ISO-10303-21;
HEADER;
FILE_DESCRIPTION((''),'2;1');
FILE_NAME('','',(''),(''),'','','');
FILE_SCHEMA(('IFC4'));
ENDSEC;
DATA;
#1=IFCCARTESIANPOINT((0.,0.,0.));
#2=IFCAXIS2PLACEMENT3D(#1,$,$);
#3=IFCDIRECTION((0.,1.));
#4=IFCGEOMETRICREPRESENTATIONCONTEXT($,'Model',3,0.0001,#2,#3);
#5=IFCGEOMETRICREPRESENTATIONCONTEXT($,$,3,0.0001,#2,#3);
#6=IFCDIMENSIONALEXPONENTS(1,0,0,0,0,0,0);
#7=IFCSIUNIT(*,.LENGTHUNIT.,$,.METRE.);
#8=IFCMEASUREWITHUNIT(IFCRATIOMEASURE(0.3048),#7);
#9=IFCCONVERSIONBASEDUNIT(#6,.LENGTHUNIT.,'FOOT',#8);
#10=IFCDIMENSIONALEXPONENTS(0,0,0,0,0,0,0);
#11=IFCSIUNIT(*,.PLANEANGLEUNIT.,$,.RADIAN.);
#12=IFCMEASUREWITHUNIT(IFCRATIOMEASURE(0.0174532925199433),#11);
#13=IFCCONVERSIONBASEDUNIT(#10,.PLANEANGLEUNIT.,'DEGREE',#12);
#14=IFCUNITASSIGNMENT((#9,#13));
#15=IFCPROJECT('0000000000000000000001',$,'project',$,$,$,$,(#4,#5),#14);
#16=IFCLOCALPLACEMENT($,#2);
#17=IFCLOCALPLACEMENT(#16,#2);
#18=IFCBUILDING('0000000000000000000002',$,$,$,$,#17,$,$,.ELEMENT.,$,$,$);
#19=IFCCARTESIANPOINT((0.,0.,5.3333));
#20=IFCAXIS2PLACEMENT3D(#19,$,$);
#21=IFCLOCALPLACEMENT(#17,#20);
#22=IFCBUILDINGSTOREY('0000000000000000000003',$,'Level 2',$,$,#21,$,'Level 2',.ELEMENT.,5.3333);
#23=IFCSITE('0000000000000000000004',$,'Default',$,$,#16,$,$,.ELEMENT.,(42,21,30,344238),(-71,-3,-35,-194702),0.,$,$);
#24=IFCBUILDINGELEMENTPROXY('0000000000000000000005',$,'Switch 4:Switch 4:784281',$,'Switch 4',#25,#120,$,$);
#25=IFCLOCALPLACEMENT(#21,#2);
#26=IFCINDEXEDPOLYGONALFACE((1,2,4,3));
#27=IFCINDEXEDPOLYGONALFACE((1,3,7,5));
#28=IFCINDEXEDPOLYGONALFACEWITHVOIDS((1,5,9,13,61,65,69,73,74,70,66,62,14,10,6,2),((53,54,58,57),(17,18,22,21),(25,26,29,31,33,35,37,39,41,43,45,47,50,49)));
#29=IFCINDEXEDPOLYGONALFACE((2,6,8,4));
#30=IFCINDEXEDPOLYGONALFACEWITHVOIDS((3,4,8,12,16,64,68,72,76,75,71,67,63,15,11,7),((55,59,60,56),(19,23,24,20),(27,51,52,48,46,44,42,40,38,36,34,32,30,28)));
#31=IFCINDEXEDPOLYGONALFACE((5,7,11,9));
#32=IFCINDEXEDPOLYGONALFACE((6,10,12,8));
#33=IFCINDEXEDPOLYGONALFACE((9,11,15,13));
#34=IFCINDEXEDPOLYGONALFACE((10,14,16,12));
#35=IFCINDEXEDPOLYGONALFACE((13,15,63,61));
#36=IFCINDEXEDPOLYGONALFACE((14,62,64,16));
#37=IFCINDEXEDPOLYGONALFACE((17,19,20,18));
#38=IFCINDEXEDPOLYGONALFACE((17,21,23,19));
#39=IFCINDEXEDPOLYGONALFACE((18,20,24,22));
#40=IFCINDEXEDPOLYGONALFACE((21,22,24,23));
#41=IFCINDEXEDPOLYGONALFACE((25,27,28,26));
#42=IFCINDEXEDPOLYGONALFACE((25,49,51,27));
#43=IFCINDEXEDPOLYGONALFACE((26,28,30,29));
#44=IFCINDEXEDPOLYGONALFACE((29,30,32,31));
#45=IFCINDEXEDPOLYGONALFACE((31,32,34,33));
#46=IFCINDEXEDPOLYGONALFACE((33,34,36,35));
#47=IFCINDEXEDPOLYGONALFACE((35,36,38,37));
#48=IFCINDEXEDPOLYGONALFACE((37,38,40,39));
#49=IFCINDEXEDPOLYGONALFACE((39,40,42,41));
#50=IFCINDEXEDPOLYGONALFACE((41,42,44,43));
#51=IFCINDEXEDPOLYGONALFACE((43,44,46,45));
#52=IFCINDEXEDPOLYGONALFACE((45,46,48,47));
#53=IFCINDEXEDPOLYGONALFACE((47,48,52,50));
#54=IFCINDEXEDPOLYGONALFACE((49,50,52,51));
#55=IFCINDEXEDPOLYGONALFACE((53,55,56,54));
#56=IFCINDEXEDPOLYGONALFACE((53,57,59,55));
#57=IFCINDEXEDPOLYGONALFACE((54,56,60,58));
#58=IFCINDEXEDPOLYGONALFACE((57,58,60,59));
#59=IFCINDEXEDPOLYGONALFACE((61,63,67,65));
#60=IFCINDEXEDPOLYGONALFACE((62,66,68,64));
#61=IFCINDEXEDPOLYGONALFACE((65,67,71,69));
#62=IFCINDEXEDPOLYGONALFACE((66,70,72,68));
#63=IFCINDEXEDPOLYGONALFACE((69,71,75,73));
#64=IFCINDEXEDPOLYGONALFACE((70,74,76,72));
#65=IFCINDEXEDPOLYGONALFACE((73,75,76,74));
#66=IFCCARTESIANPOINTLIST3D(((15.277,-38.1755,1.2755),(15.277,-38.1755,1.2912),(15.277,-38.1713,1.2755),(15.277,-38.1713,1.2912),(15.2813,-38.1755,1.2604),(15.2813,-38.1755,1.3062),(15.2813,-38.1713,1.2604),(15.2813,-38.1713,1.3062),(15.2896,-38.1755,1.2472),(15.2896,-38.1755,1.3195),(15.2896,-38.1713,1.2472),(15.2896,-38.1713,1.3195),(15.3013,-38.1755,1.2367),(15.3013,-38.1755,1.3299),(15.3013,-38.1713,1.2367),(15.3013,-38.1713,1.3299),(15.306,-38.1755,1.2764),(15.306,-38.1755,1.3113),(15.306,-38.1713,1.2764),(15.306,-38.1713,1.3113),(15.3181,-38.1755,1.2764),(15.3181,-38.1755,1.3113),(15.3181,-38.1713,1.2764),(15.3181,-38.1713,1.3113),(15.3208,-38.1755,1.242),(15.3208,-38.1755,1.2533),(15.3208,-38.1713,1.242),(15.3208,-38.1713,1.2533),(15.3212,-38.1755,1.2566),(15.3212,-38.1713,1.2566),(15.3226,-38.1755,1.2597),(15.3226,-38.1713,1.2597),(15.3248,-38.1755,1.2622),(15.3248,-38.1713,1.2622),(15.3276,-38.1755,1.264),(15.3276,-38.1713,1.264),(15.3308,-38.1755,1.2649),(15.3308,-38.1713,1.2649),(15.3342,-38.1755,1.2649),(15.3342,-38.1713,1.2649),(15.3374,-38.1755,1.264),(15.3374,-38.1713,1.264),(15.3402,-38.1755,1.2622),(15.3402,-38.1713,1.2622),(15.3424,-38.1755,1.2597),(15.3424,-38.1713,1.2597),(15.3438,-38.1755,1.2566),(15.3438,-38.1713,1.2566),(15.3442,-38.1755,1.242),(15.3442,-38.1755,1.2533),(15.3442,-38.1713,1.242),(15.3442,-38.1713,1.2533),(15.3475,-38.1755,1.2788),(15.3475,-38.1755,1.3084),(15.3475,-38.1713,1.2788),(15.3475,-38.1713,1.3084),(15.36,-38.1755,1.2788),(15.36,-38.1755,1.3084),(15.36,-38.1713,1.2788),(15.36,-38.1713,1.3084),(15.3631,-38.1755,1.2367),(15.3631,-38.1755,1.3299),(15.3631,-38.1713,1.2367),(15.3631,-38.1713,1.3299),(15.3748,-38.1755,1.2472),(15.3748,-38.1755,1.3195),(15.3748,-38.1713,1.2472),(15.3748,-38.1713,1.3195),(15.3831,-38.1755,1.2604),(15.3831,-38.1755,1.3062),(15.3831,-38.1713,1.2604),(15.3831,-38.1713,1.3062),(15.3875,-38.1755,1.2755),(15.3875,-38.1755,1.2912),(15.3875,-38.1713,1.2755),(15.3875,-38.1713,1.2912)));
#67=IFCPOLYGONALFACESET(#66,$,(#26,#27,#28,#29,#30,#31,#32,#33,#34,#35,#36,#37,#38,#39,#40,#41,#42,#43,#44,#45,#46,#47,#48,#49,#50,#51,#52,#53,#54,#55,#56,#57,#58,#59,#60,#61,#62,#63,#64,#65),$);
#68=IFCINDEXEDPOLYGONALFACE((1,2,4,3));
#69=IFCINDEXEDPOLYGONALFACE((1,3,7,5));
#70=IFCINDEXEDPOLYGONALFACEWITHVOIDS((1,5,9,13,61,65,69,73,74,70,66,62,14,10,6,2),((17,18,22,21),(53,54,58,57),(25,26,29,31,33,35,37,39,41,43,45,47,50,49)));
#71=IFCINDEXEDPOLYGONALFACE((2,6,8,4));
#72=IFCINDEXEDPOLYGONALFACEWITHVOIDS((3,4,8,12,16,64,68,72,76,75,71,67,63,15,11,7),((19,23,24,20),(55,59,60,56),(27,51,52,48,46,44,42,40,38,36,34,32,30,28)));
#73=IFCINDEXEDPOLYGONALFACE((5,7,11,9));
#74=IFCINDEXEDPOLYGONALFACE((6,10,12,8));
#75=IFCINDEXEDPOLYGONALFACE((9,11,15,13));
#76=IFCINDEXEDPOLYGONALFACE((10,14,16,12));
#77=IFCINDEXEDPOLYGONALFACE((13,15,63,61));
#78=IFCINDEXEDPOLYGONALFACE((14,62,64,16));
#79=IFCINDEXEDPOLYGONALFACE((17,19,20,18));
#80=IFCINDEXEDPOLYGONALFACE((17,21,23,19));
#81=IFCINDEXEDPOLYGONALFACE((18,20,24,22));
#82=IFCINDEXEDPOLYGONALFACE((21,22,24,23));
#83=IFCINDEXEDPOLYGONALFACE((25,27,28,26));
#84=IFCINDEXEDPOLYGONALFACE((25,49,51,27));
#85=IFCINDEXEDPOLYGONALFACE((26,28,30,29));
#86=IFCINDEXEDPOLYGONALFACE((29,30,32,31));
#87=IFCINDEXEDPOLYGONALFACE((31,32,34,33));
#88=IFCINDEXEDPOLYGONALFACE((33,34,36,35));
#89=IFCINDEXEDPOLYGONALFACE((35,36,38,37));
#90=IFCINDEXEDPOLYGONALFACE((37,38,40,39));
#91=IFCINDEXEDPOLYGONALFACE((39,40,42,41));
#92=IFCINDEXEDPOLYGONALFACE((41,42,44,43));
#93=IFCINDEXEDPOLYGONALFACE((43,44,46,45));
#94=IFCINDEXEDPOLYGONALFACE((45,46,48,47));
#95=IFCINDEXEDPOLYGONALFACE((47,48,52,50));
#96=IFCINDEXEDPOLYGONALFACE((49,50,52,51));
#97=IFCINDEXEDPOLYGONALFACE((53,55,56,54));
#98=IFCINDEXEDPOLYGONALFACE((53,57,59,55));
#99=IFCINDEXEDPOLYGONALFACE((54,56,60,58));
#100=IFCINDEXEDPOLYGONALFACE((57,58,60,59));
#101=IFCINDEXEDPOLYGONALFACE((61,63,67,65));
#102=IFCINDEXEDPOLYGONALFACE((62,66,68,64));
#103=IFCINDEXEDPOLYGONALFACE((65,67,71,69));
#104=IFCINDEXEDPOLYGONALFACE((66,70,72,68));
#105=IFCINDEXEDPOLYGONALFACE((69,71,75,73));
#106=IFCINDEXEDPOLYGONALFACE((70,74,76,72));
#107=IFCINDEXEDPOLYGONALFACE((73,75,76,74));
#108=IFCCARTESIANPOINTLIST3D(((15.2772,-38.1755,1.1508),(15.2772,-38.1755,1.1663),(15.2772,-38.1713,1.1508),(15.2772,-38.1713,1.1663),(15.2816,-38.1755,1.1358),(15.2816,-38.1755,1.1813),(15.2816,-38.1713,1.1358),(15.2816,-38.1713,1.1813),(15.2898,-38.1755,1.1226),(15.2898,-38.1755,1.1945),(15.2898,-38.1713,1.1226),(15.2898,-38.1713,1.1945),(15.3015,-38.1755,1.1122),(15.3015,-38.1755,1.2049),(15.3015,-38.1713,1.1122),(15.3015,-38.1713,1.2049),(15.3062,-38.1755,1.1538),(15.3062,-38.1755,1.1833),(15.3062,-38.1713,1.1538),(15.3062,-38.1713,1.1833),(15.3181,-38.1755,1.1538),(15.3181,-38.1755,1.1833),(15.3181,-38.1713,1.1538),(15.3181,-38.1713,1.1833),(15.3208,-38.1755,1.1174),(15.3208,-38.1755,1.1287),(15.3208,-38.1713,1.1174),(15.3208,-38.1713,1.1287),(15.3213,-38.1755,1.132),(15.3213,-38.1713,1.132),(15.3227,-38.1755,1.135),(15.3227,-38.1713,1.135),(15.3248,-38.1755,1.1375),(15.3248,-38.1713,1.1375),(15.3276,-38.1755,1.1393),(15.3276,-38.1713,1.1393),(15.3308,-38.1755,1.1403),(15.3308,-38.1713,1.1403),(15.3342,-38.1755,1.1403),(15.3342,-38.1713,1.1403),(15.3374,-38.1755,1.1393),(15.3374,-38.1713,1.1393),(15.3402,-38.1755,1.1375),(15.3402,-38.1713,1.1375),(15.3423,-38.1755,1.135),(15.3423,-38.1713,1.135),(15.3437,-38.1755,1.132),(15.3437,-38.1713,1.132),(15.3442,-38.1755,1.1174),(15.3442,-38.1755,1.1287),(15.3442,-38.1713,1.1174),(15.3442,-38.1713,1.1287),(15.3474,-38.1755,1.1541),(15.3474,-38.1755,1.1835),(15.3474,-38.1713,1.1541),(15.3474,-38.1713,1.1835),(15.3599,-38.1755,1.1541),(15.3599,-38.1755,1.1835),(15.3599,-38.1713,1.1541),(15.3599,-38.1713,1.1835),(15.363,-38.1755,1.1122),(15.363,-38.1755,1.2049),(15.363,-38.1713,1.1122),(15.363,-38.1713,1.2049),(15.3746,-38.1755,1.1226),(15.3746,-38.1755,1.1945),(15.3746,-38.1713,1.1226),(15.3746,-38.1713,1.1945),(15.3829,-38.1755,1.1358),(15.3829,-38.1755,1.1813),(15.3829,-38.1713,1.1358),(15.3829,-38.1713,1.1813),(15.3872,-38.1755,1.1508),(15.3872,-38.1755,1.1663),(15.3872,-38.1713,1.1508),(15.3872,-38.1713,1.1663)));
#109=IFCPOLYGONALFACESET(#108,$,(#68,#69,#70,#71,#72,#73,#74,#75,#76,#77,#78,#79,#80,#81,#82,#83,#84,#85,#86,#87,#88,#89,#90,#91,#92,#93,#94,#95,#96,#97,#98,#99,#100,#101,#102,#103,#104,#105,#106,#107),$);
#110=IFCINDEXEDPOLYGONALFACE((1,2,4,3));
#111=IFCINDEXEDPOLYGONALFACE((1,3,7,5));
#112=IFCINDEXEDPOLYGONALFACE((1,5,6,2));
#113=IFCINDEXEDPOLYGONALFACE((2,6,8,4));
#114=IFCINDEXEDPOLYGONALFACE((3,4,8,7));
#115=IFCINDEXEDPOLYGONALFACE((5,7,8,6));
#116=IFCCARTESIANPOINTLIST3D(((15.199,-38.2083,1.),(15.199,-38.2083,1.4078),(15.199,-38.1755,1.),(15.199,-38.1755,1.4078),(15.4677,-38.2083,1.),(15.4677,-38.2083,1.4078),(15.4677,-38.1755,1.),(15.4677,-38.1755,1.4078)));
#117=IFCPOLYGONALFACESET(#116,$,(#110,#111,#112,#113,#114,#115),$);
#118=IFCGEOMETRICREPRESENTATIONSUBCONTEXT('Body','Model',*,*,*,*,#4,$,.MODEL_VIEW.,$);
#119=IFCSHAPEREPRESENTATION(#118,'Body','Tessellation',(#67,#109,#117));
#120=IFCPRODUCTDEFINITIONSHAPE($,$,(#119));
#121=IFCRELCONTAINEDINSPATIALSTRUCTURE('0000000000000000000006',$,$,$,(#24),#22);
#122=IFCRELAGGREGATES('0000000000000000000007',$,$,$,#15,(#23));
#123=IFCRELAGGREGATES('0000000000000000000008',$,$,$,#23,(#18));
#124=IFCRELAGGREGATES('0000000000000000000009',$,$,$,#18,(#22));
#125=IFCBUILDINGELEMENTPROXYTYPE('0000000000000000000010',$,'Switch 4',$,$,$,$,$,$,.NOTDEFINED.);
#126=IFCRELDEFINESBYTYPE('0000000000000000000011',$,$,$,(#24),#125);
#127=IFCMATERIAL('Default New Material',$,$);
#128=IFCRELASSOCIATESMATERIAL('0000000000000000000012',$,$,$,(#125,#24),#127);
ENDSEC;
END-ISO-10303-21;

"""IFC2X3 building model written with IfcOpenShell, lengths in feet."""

from ifc_helpers import new_model, entity, si_unit, converted_unit, direction, frame, frame_2d, origin, origin_2d_with_axis, place, context, subcontext, project, spatial, polyline, circle_curve, parameter, trimmed, segment, composite_curve, rectangle, outline, extrude, source, transform, mapped, material, type_object, type_shapes, element, save


model = new_model("IFC2X3")

# Units and contexts
model_context = context("Model", 3, precision=0.0001, world=origin(), true_north=direction((0.0, 1.0)))
context_of_model = context(None, 3, precision=0.0001, world=origin(), true_north=direction((0.0, 1.0)))
body_context = subcontext(model_context, "Body", "Model", "MODEL_VIEW")
ifc_project = project(units=[converted_unit("LENGTHUNIT", "FOOT", entity("IfcRatioMeasure", 0.3048), si_unit("LENGTHUNIT", "METRE"), dimensions=[1, 0, 0, 0, 0, 0, 0]), converted_unit("PLANEANGLEUNIT", "DEGREE", entity("IfcRatioMeasure", 0.0174532925199433), si_unit("PLANEANGLEUNIT", "RADIAN"), dimensions=[0, 0, 0, 0, 0, 0, 0])], contexts=[model_context, context_of_model])

# Site, building, storey
site_placement = place(None, origin())
site = spatial("IfcSite", under=ifc_project, at=site_placement, Name="Default", CompositionType="ELEMENT", RefLatitude=(42, 21, 30, 344238), RefLongitude=(-71, -3, -35, -194702), RefElevation=0.0)
building_placement = place(site_placement, origin())
building = spatial("IfcBuilding", under=site, at=building_placement, CompositionType="ELEMENT")
storey_placement = place(building_placement, frame((0.0, 0.0, 5.3333)))
storey = spatial("IfcBuildingStorey", under=building, at=storey_placement, Name="Level 2", LongName="Level 2", CompositionType="ELEMENT", Elevation=5.3333)

# Shared definitions
ifc_material_1 = material(Name="Default New Material")

# Building element proxy
building_element_proxy_type_1 = type_object("IfcBuildingElementProxyType", Name="Switch 4", PredefinedType="NOTDEFINED", material=ifc_material_1)
shared_shape_1 = source(origin(), body_context, "Body", "SweptSolid", [
    extrude(outline(composite_curve([segment(polyline([(-0.0309, -0.0466), (0.0309, -0.0466)]), True, "CONTINUOUS"), segment(trimmed(circle_curve(frame_2d((-0.0003, 0.0), x_axis=(-1.0, 0.0)), 0.0561), [parameter(123.794741)], [parameter(236.205259)], True, "PARAMETER"), True, "CONTINUOUS"), segment(polyline([(0.0309, 0.0466), (-0.0309, 0.0466)]), True, "CONTINUOUS"), segment(trimmed(circle_curve(frame_2d((0.0003, 0.0), x_axis=(1.0, 0.0)), 0.0561), [parameter(123.794741)], [parameter(236.205259)], True, "PARAMETER"), True, "CONTINUOUS")], self_intersect=False), holes=[polyline([(0.0142, 0.0279), (0.0262, 0.0279), (0.0262, -0.0069), (0.0142, -0.0069), (0.0142, 0.0279)]), polyline([(-0.0153, 0.025), (-0.0153, -0.0045), (-0.0278, -0.0045), (-0.0278, 0.025), (-0.0153, 0.025)]), composite_curve([segment(polyline([(-0.012, -0.0413), (-0.012, -0.03)]), True, "CONTINUOUS"), segment(trimmed(circle_curve(frame_2d((-0.0003, -0.03), x_axis=(-1.0, 0.0)), 0.0117), [parameter(180.0)], [parameter(0.0)], True, "PARAMETER"), False, "CONTINUOUS"), segment(polyline([(0.0115, -0.03), (0.0115, -0.0413)]), True, "CONTINUOUS"), segment(polyline([(0.0115, -0.0413), (-0.012, -0.0413)]), True, "CONTINUOUS")], self_intersect=False)]), frame((-0.0011, 0.0328, 0.2833), z_axis=(0.0, 1.0, 0.0), x_axis=(-1.0, 0.0, 0.0)), (0.0, 0.0, 1.0), 0.0042),
    extrude(outline(composite_curve([segment(polyline([(-0.0308, -0.0464), (0.0308, -0.0464)]), True, "CONTINUOUS"), segment(trimmed(circle_curve(frame_2d((-0.0003, 0.0), x_axis=(-1.0, 0.0)), 0.0558), [parameter(123.794741)], [parameter(236.205259)], True, "PARAMETER"), True, "CONTINUOUS"), segment(polyline([(0.0308, 0.0464), (-0.0308, 0.0464)]), True, "CONTINUOUS"), segment(trimmed(circle_curve(frame_2d((0.0003, 0.0), x_axis=(1.0, 0.0)), 0.0558), [parameter(123.794741)], [parameter(236.205259)], True, "PARAMETER"), True, "CONTINUOUS")], self_intersect=False), holes=[polyline([(0.0141, 0.0247), (0.026, 0.0247), (0.026, -0.0047), (0.0141, -0.0047), (0.0141, 0.0247)]), polyline([(-0.0152, 0.0249), (-0.0152, -0.0045), (-0.0277, -0.0045), (-0.0277, 0.0249), (-0.0152, 0.0249)]), composite_curve([segment(polyline([(-0.012, -0.0411), (-0.012, -0.0299)]), True, "CONTINUOUS"), segment(trimmed(circle_curve(frame_2d((-0.0003, -0.0299), x_axis=(-1.0, 0.0)), 0.0117), [parameter(180.0)], [parameter(0.0)], True, "PARAMETER"), False, "CONTINUOUS"), segment(polyline([(0.0114, -0.0299), (0.0114, -0.0411)]), True, "CONTINUOUS"), segment(polyline([(0.0114, -0.0411), (-0.012, -0.0411)]), True, "CONTINUOUS")], self_intersect=False)]), frame((-0.0011, 0.0328, 0.1586), z_axis=(0.0, 1.0, 0.0), x_axis=(-1.0, 0.0, 0.0)), (0.0, 0.0, 1.0), 0.0042),
    extrude(rectangle(XDim=0.0328, YDim=0.2687, at=origin_2d_with_axis()), frame((0.0, 0.0164, 0.0), z_axis=(0.0, 0.0, 1.0), x_axis=(0.0, -1.0, 0.0)), (0.0, 0.0, 1.0), 0.4078),
])
type_shapes(building_element_proxy_type_1, [shared_shape_1])
for number, where, name in (
    (1, (15.3333, -38.2083, 1.0), "Switch 4:Switch 4:784281"),
):
    element("IfcBuildingElementProxy", number, at=place(storey_placement, frame(where)), inside=storey, type_object=building_element_proxy_type_1, material=ifc_material_1, Name=name, ObjectType="Switch 4", context=body_context, shape_type="MappedRepresentation", body=[
        mapped(shared_shape_1, transform((0.0, 0.0, 0.0), scale=1.0)),
    ])

save(model, "model.ifc")
